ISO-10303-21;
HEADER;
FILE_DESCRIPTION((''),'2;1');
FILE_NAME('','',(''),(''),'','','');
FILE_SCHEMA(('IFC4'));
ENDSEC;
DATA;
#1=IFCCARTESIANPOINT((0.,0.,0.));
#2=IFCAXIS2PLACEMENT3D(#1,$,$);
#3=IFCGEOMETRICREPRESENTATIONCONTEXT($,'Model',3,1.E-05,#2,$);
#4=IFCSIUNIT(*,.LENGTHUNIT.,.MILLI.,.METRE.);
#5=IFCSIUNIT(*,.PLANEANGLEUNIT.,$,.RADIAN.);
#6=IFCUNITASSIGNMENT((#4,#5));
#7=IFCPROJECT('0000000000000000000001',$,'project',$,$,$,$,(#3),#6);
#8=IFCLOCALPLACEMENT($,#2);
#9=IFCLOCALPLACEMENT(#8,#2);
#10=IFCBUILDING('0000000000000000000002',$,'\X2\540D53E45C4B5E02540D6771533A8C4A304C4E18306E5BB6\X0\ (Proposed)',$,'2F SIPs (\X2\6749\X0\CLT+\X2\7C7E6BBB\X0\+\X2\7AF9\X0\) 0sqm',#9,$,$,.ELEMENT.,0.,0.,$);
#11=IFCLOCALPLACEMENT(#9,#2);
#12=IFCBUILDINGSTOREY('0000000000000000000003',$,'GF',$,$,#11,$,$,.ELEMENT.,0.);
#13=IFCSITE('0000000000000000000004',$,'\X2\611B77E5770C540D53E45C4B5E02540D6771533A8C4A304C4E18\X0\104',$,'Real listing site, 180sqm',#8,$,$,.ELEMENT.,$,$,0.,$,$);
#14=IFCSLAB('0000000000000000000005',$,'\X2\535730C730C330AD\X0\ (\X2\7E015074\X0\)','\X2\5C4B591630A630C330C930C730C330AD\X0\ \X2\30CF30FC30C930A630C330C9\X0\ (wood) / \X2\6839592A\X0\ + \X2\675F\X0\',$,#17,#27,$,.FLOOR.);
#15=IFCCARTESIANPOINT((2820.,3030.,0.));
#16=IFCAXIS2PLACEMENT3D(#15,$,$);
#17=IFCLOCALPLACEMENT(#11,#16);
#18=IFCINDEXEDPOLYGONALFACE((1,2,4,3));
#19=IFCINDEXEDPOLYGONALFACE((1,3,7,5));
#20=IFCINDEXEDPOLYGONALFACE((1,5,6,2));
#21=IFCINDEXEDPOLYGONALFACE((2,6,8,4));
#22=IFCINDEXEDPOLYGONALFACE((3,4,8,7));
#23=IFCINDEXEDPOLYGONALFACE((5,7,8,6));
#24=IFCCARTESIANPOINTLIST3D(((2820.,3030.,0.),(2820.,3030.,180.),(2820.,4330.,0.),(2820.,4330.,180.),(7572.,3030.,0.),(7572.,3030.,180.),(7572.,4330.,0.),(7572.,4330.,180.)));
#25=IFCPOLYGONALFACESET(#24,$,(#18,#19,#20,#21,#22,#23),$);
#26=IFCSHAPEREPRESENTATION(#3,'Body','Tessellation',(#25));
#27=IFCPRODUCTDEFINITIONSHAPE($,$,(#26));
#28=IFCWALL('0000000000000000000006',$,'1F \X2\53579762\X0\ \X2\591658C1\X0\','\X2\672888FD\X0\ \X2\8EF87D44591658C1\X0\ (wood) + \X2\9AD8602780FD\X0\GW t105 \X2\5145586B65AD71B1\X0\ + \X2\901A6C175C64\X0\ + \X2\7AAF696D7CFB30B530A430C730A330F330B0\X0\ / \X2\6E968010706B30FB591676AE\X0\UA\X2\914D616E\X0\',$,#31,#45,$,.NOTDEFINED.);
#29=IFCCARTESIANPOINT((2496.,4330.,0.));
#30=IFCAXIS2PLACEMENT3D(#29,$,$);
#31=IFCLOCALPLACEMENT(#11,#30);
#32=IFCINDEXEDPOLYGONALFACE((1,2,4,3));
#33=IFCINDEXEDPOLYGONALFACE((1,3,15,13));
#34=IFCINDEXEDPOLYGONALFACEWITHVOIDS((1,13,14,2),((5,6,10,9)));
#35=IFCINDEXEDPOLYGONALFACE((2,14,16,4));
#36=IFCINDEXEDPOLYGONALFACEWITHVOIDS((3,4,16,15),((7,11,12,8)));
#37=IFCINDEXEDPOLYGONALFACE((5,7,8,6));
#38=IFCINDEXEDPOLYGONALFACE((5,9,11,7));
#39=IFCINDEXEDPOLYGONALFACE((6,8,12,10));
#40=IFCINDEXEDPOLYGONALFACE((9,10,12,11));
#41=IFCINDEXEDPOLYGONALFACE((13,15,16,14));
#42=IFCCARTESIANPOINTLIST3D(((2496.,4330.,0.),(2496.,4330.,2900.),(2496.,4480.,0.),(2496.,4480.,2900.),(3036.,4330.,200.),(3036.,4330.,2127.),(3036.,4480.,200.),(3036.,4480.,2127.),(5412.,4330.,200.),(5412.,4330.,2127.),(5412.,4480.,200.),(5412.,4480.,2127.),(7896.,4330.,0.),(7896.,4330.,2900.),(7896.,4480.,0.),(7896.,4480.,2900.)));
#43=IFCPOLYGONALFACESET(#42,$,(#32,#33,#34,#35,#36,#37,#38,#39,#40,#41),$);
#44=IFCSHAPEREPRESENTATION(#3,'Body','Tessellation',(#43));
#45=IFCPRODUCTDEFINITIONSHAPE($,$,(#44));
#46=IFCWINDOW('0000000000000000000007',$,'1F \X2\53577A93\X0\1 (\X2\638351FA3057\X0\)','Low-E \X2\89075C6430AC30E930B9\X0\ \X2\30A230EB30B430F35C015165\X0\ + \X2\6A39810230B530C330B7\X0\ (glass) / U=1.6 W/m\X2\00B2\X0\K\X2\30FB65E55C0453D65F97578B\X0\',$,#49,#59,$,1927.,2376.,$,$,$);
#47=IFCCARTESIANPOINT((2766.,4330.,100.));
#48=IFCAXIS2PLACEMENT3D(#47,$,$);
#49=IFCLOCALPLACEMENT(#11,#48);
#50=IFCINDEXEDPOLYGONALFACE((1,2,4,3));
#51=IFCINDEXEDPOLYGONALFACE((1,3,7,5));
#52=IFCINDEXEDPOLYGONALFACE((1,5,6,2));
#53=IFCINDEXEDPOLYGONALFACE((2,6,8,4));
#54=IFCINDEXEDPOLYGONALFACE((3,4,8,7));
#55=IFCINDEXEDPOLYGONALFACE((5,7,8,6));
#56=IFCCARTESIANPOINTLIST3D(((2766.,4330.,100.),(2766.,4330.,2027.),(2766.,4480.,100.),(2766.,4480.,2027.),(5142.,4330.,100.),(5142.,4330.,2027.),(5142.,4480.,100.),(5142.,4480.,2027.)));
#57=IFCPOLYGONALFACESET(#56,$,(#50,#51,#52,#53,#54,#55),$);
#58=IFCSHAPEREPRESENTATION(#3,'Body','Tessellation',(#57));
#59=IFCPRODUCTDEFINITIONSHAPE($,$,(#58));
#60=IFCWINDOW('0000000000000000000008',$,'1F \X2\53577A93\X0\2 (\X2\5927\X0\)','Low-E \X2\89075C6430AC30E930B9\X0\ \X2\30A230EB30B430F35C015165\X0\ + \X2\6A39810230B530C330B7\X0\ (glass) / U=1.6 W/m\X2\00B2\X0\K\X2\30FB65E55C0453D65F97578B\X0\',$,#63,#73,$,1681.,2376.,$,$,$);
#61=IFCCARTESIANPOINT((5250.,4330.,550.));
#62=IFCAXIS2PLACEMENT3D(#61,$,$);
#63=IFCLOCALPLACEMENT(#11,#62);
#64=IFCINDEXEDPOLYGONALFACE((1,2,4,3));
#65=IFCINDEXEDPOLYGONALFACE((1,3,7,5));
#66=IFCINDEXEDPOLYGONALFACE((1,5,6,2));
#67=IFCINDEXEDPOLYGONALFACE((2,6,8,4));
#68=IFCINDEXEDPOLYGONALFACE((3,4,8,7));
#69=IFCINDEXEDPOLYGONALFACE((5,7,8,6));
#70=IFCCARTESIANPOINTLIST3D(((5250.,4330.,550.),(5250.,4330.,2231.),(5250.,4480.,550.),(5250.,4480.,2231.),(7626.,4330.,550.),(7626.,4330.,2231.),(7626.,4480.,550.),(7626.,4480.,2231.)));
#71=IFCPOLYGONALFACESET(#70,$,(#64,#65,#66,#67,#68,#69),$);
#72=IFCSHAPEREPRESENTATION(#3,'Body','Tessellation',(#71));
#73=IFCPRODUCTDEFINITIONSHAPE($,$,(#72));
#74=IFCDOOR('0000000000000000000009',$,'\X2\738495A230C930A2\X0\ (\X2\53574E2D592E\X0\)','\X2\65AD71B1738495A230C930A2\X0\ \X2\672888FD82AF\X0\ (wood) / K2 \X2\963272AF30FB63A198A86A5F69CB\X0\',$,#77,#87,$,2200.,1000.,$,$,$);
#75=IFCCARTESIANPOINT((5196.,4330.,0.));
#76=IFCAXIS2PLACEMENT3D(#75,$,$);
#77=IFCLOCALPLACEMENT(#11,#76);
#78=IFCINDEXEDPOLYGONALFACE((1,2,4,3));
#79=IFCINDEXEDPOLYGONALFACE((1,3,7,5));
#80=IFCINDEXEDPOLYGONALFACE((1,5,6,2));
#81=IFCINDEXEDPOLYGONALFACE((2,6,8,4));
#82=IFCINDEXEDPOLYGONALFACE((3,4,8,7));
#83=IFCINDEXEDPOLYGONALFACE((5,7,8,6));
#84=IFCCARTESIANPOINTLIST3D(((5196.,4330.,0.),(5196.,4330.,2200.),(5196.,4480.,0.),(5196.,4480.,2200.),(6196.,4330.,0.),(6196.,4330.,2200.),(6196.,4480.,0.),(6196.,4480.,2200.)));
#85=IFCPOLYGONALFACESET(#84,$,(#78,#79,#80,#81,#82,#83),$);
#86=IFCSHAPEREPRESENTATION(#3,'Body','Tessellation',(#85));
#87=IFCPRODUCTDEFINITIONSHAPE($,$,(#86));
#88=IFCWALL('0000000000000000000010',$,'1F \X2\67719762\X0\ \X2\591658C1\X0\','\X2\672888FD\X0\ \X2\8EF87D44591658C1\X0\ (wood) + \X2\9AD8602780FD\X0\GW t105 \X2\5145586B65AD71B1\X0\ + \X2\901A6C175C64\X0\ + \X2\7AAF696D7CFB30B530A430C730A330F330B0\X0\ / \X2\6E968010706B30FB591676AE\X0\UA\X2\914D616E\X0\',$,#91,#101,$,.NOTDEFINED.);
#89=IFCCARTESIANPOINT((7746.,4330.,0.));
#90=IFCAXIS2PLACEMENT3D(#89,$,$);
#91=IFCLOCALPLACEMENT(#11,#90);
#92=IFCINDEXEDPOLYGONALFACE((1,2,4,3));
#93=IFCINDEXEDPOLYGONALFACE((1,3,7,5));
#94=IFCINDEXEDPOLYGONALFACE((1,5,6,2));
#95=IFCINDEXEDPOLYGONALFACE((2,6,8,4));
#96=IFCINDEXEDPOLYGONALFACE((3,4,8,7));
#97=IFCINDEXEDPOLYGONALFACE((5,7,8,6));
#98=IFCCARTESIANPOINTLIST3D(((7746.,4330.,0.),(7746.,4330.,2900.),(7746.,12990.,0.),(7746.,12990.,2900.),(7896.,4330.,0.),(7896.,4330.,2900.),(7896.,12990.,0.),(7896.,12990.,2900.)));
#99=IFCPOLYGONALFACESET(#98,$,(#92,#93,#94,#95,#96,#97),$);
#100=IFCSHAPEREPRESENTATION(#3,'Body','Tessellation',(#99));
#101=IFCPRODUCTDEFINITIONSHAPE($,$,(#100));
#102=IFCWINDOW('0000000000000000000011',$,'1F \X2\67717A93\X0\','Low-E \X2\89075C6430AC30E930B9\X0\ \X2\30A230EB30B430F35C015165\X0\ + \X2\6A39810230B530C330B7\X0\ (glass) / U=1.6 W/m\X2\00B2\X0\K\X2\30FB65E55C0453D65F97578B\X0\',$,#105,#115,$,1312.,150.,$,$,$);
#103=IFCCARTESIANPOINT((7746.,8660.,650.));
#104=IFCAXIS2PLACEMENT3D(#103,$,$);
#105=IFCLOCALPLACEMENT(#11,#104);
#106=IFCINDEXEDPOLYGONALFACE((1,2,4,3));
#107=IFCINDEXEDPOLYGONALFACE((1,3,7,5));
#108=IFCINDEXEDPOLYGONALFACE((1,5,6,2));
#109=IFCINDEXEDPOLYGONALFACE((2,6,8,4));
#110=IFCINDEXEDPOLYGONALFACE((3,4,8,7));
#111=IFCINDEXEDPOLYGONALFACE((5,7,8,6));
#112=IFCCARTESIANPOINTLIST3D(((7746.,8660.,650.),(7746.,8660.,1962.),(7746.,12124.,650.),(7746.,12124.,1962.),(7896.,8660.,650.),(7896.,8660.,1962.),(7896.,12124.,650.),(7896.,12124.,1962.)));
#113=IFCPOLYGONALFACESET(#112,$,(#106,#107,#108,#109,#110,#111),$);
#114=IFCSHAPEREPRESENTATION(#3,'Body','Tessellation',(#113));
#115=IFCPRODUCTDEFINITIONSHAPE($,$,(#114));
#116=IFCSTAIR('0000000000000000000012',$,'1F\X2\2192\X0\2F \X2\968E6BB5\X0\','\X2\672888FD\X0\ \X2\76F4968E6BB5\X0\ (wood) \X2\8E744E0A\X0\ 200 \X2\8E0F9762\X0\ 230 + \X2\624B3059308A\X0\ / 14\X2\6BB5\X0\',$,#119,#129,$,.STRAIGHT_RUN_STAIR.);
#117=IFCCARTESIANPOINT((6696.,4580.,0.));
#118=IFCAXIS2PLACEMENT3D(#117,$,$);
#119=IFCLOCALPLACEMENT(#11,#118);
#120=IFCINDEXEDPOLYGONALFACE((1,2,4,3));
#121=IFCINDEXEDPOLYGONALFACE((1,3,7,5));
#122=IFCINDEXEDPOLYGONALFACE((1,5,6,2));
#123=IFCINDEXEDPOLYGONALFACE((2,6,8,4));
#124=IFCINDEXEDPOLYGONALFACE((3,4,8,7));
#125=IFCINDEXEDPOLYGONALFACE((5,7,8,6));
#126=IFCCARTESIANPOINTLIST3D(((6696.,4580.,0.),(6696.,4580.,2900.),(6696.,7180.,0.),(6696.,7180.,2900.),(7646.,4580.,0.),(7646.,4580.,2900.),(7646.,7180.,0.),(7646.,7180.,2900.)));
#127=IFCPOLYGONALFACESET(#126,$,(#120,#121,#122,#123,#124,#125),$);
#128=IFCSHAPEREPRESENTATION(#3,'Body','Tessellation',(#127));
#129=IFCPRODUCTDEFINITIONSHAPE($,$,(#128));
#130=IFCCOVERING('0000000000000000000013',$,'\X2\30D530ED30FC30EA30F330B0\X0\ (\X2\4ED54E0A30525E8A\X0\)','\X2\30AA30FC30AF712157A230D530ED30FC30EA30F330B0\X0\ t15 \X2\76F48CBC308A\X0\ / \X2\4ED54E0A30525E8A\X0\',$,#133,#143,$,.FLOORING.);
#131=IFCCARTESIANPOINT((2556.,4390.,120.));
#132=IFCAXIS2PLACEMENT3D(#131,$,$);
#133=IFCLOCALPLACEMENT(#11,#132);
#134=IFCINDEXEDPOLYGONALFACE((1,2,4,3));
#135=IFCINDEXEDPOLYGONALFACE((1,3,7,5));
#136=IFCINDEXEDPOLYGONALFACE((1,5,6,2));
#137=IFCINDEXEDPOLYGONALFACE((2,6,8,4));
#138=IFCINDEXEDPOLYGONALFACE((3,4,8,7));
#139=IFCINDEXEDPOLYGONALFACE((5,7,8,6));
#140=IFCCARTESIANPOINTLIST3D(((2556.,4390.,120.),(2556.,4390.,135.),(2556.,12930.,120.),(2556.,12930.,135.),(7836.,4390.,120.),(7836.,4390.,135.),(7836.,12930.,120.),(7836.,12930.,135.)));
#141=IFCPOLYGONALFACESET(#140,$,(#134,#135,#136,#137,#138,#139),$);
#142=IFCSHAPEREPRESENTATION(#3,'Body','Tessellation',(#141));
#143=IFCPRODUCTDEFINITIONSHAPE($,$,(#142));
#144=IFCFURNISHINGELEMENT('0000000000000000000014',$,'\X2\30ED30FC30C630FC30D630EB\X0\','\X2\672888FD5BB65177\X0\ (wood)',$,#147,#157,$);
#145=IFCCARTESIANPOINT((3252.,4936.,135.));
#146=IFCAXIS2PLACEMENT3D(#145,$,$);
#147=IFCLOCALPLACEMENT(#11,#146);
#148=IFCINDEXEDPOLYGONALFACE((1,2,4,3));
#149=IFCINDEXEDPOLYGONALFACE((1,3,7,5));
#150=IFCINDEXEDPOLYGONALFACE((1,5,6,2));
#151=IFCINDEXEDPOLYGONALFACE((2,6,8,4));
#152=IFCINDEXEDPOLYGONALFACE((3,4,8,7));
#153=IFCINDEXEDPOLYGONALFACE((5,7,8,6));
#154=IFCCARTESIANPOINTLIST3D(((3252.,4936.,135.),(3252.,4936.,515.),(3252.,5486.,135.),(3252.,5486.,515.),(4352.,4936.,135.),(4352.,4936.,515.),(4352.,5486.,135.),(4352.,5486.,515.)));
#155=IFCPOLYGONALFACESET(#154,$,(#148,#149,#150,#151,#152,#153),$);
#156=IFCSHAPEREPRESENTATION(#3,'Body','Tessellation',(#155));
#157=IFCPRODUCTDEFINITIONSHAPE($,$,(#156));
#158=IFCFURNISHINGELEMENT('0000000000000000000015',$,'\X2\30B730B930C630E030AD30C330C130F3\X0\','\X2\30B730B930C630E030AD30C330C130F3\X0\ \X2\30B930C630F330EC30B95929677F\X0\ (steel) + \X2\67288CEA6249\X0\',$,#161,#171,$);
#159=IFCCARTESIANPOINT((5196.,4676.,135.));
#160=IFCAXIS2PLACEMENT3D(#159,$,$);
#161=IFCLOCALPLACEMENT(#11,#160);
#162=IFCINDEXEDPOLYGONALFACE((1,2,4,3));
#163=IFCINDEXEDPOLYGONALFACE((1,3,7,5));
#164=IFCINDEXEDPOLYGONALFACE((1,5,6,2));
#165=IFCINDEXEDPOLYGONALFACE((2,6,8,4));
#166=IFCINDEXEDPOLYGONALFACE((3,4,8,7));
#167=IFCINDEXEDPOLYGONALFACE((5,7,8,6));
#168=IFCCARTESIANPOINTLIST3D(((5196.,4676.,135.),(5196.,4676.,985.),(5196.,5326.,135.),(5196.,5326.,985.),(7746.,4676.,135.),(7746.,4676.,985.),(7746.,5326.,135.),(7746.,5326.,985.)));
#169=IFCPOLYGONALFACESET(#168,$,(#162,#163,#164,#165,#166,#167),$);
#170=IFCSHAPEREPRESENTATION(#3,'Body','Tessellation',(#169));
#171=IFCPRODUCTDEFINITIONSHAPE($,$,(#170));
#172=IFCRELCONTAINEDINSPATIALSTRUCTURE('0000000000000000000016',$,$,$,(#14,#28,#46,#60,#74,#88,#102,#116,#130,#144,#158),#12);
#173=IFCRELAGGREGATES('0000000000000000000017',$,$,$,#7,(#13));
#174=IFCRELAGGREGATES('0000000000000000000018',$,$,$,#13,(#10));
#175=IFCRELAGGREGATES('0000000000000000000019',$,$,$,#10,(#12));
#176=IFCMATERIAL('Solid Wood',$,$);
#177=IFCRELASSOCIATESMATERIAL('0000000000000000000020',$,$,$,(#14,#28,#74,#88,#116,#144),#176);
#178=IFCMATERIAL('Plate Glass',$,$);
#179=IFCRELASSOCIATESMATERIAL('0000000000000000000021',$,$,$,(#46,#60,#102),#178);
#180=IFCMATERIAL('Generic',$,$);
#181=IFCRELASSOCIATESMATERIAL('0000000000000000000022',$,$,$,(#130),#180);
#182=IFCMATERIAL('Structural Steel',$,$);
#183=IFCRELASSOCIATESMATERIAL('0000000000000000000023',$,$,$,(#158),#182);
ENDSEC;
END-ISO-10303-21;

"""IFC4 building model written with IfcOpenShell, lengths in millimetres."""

from ifc_helpers import new_model, si_unit, frame, frame_2d, origin, place, context, project, spatial, rectangle, extrude, material, element, fill, save


model = new_model("IFC4")

# Units and contexts
model_context = context("Model", 3, precision=1e-05, world=origin())
ifc_project = project(units=[si_unit("LENGTHUNIT", "METRE", prefix="MILLI"), si_unit("PLANEANGLEUNIT", "RADIAN")], contexts=[model_context])

# Site, building, storey
site_placement = place(None, origin())
site = spatial("IfcSite", under=ifc_project, at=site_placement, Name="愛知県名古屋市名東区豊が丘104", ObjectType="Real listing site, 180sqm", CompositionType="ELEMENT", RefElevation=0.0)
building_placement = place(site_placement, origin())
building = spatial("IfcBuilding", under=site, at=building_placement, Name="名古屋市名東区豊が丘の家 (Proposed)", ObjectType="2F SIPs (杉CLT+籾殻+竹) 0sqm", CompositionType="ELEMENT", ElevationOfRefHeight=0.0, ElevationOfTerrain=0.0)
storey_placement = place(building_placement, origin())
storey = spatial("IfcBuildingStorey", under=building, at=storey_placement, Name="GF", CompositionType="ELEMENT", Elevation=0.0)

# Slab
ifc_material_1 = material(Name="Solid Wood")
slab_1_placement = place(storey_placement, frame((2820.0, 3030.0, 0.0)))
element("IfcSlab", 1, at=slab_1_placement, inside=storey, material=ifc_material_1, Name="南デッキ (縁側)", Description="屋外ウッドデッキ ハードウッド (wood) / 根太 + 束", PredefinedType="FLOOR", context=model_context, shape_type="SweptSolid", body=[
    extrude(rectangle(XDim=4752.0, YDim=1300.0, at=frame_2d((2376.0, 650.0))), frame((2820.0, 3030.0, 0.0)), (0.0, 0.0, 1.0), 180.0),
])

# Wall, openings, windows, door
wall_1_placement = place(storey_placement, frame((2496.0, 4330.0, 0.0)))
wall_1 = element("IfcWall", 2, at=wall_1_placement, inside=storey, material=ifc_material_1, Name="1F 南面 外壁", Description="木製 軸組外壁 (wood) + 高性能GW t105 充填断熱 + 通気層 + 窯業系サイディング / 準耐火・外皮UA配慮", PredefinedType="NOTDEFINED", context=model_context, shape_type="SweptSolid", body=[
    extrude(rectangle(XDim=5400.0, YDim=150.0, at=frame_2d((2700.0, 75.0))), frame((2496.0, 4330.0, 0.0)), (0.0, 0.0, 1.0), 2900.0),
])
opening_1_placement = place(storey_placement, frame((2766.0, 4330.0, 100.0)))
opening_1 = element("IfcOpeningElement", 3, at=opening_1_placement, cuts=wall_1, PredefinedType="NOTDEFINED", context=model_context, shape_type="SweptSolid", body=[
    extrude(rectangle(XDim=2376.0, YDim=150.0, at=frame_2d((1188.0, 75.0))), frame((2766.0, 4330.0, 100.0)), (0.0, 0.0, 1.0), 1927.0),
])
opening_2_placement = place(storey_placement, frame((5250.0, 4330.0, 550.0)))
opening_2 = element("IfcOpeningElement", 4, at=opening_2_placement, cuts=wall_1, PredefinedType="NOTDEFINED", context=model_context, shape_type="SweptSolid", body=[
    extrude(rectangle(XDim=2376.0, YDim=150.0, at=frame_2d((1188.0, 75.0))), frame((5250.0, 4330.0, 550.0)), (0.0, 0.0, 1.0), 1681.0),
])
opening_3_placement = place(storey_placement, frame((5196.0, 4330.0, 0.0)))
opening_3 = element("IfcOpeningElement", 5, at=opening_3_placement, cuts=wall_1, PredefinedType="NOTDEFINED", context=model_context, shape_type="SweptSolid", body=[
    extrude(rectangle(XDim=1000.0, YDim=150.0, at=frame_2d((500.0, 75.0))), frame((5196.0, 4330.0, 0.0)), (0.0, 0.0, 1.0), 2200.0),
])
ifc_material_2 = material(Name="Plate Glass")
window_1_placement = place(storey_placement, frame((2766.0, 4330.0, 100.0)))
window_1 = element("IfcWindow", 6, at=window_1_placement, inside=storey, material=ifc_material_2, Name="1F 南窓1 (掃出し)", Description="Low-E 複層ガラス アルゴン封入 + 樹脂サッシ (glass) / U=1.6 W/m²K・日射取得型", OverallHeight=1927.0, OverallWidth=2376.0, context=model_context, shape_type="SweptSolid", body=[
    extrude(rectangle(XDim=2376.0, YDim=150.0, at=frame_2d((1188.0, 75.0))), frame((2766.0, 4330.0, 100.0)), (0.0, 0.0, 1.0), 1927.0),
])
fill(opening_1, window_1)
window_2_placement = place(storey_placement, frame((5250.0, 4330.0, 550.0)))
window_2 = element("IfcWindow", 7, at=window_2_placement, inside=storey, material=ifc_material_2, Name="1F 南窓2 (大)", Description="Low-E 複層ガラス アルゴン封入 + 樹脂サッシ (glass) / U=1.6 W/m²K・日射取得型", OverallHeight=1681.0, OverallWidth=2376.0, context=model_context, shape_type="SweptSolid", body=[
    extrude(rectangle(XDim=2376.0, YDim=150.0, at=frame_2d((1188.0, 75.0))), frame((5250.0, 4330.0, 550.0)), (0.0, 0.0, 1.0), 1681.0),
])
fill(opening_2, window_2)
door_placement = place(storey_placement, frame((5196.0, 4330.0, 0.0)))
door = element("IfcDoor", 8, at=door_placement, inside=storey, material=ifc_material_1, Name="玄関ドア (南中央)", Description="断熱玄関ドア 木製芯 (wood) / K2 防犯・採風機構", OverallHeight=2200.0, OverallWidth=1000.0, context=model_context, shape_type="SweptSolid", body=[
    extrude(rectangle(XDim=1000.0, YDim=150.0, at=frame_2d((500.0, 75.0))), frame((5196.0, 4330.0, 0.0)), (0.0, 0.0, 1.0), 2200.0),
])
fill(opening_3, door)

# Wall, opening, window
wall_2_placement = place(storey_placement, frame((7746.0, 4330.0, 0.0)))
wall_2 = element("IfcWall", 9, at=wall_2_placement, inside=storey, material=ifc_material_1, Name="1F 東面 外壁", Description="木製 軸組外壁 (wood) + 高性能GW t105 充填断熱 + 通気層 + 窯業系サイディング / 準耐火・外皮UA配慮", PredefinedType="NOTDEFINED", context=model_context, shape_type="SweptSolid", body=[
    extrude(rectangle(XDim=150.0, YDim=8660.0, at=frame_2d((75.0, 4330.0))), frame((7746.0, 4330.0, 0.0)), (0.0, 0.0, 1.0), 2900.0),
])
opening_4_placement = place(storey_placement, frame((7746.0, 8660.0, 650.0)))
opening_4 = element("IfcOpeningElement", 10, at=opening_4_placement, cuts=wall_2, PredefinedType="NOTDEFINED", context=model_context, shape_type="SweptSolid", body=[
    extrude(rectangle(XDim=150.0, YDim=3464.0, at=frame_2d((75.0, 1732.0))), frame((7746.0, 8660.0, 650.0)), (0.0, 0.0, 1.0), 1312.0),
])
window_3_placement = place(storey_placement, frame((7746.0, 8660.0, 650.0)))
window_3 = element("IfcWindow", 11, at=window_3_placement, inside=storey, material=ifc_material_2, Name="1F 東窓", Description="Low-E 複層ガラス アルゴン封入 + 樹脂サッシ (glass) / U=1.6 W/m²K・日射取得型", OverallHeight=1312.0, OverallWidth=150.0, context=model_context, shape_type="SweptSolid", body=[
    extrude(rectangle(XDim=150.0, YDim=3464.0, at=frame_2d((75.0, 1732.0))), frame((7746.0, 8660.0, 650.0)), (0.0, 0.0, 1.0), 1312.0),
])
fill(opening_4, window_3)

# Stair
stair_placement = place(storey_placement, frame((6696.0, 4580.0, 0.0)))
element("IfcStair", 12, at=stair_placement, inside=storey, material=ifc_material_1, Name="1F→2F 階段", Description="木製 直階段 (wood) 蹴上 200 踏面 230 + 手すり / 14段", PredefinedType="STRAIGHT_RUN_STAIR", context=model_context, shape_type="SweptSolid", body=[
    extrude(rectangle(XDim=950.0, YDim=2600.0, at=frame_2d((475.0, 1300.0))), frame((6696.0, 4580.0, 0.0)), (0.0, 0.0, 1.0), 2900.0),
])

# Covering
ifc_material_3 = material(Name="Generic")
covering_placement = place(storey_placement, frame((2556.0, 4390.0, 120.0)))
element("IfcCovering", 13, at=covering_placement, inside=storey, material=ifc_material_3, Name="フローリング (仕上げ床)", Description="オーク無垢フローリング t15 直貼り / 仕上げ床", PredefinedType="FLOORING", context=model_context, shape_type="SweptSolid", body=[
    extrude(rectangle(XDim=5280.0, YDim=8540.0, at=frame_2d((2640.0, 4270.0))), frame((2556.0, 4390.0, 120.0)), (0.0, 0.0, 1.0), 15.0),
])

# Furnishing elements
furnishing_1_placement = place(storey_placement, frame((3252.0, 4936.0, 135.0)))
element("IfcFurnishingElement", 14, at=furnishing_1_placement, inside=storey, material=ifc_material_1, Name="ローテーブル", Description="木製家具 (wood)", context=model_context, shape_type="SweptSolid", body=[
    extrude(rectangle(XDim=1100.0, YDim=550.0, at=frame_2d((550.0, 275.0))), frame((3252.0, 4936.0, 135.0)), (0.0, 0.0, 1.0), 380.0),
])
ifc_material_4 = material(Name="Structural Steel")
furnishing_2_placement = place(storey_placement, frame((5196.0, 4676.0, 135.0)))
element("IfcFurnishingElement", 15, at=furnishing_2_placement, inside=storey, material=ifc_material_4, Name="システムキッチン", Description="システムキッチン ステンレス天板 (steel) + 木質扉", context=model_context, shape_type="SweptSolid", body=[
    extrude(rectangle(XDim=2550.0, YDim=650.0, at=frame_2d((1275.0, 325.0))), frame((5196.0, 4676.0, 135.0)), (0.0, 0.0, 1.0), 850.0),
])

save(model, "model.ifc")
